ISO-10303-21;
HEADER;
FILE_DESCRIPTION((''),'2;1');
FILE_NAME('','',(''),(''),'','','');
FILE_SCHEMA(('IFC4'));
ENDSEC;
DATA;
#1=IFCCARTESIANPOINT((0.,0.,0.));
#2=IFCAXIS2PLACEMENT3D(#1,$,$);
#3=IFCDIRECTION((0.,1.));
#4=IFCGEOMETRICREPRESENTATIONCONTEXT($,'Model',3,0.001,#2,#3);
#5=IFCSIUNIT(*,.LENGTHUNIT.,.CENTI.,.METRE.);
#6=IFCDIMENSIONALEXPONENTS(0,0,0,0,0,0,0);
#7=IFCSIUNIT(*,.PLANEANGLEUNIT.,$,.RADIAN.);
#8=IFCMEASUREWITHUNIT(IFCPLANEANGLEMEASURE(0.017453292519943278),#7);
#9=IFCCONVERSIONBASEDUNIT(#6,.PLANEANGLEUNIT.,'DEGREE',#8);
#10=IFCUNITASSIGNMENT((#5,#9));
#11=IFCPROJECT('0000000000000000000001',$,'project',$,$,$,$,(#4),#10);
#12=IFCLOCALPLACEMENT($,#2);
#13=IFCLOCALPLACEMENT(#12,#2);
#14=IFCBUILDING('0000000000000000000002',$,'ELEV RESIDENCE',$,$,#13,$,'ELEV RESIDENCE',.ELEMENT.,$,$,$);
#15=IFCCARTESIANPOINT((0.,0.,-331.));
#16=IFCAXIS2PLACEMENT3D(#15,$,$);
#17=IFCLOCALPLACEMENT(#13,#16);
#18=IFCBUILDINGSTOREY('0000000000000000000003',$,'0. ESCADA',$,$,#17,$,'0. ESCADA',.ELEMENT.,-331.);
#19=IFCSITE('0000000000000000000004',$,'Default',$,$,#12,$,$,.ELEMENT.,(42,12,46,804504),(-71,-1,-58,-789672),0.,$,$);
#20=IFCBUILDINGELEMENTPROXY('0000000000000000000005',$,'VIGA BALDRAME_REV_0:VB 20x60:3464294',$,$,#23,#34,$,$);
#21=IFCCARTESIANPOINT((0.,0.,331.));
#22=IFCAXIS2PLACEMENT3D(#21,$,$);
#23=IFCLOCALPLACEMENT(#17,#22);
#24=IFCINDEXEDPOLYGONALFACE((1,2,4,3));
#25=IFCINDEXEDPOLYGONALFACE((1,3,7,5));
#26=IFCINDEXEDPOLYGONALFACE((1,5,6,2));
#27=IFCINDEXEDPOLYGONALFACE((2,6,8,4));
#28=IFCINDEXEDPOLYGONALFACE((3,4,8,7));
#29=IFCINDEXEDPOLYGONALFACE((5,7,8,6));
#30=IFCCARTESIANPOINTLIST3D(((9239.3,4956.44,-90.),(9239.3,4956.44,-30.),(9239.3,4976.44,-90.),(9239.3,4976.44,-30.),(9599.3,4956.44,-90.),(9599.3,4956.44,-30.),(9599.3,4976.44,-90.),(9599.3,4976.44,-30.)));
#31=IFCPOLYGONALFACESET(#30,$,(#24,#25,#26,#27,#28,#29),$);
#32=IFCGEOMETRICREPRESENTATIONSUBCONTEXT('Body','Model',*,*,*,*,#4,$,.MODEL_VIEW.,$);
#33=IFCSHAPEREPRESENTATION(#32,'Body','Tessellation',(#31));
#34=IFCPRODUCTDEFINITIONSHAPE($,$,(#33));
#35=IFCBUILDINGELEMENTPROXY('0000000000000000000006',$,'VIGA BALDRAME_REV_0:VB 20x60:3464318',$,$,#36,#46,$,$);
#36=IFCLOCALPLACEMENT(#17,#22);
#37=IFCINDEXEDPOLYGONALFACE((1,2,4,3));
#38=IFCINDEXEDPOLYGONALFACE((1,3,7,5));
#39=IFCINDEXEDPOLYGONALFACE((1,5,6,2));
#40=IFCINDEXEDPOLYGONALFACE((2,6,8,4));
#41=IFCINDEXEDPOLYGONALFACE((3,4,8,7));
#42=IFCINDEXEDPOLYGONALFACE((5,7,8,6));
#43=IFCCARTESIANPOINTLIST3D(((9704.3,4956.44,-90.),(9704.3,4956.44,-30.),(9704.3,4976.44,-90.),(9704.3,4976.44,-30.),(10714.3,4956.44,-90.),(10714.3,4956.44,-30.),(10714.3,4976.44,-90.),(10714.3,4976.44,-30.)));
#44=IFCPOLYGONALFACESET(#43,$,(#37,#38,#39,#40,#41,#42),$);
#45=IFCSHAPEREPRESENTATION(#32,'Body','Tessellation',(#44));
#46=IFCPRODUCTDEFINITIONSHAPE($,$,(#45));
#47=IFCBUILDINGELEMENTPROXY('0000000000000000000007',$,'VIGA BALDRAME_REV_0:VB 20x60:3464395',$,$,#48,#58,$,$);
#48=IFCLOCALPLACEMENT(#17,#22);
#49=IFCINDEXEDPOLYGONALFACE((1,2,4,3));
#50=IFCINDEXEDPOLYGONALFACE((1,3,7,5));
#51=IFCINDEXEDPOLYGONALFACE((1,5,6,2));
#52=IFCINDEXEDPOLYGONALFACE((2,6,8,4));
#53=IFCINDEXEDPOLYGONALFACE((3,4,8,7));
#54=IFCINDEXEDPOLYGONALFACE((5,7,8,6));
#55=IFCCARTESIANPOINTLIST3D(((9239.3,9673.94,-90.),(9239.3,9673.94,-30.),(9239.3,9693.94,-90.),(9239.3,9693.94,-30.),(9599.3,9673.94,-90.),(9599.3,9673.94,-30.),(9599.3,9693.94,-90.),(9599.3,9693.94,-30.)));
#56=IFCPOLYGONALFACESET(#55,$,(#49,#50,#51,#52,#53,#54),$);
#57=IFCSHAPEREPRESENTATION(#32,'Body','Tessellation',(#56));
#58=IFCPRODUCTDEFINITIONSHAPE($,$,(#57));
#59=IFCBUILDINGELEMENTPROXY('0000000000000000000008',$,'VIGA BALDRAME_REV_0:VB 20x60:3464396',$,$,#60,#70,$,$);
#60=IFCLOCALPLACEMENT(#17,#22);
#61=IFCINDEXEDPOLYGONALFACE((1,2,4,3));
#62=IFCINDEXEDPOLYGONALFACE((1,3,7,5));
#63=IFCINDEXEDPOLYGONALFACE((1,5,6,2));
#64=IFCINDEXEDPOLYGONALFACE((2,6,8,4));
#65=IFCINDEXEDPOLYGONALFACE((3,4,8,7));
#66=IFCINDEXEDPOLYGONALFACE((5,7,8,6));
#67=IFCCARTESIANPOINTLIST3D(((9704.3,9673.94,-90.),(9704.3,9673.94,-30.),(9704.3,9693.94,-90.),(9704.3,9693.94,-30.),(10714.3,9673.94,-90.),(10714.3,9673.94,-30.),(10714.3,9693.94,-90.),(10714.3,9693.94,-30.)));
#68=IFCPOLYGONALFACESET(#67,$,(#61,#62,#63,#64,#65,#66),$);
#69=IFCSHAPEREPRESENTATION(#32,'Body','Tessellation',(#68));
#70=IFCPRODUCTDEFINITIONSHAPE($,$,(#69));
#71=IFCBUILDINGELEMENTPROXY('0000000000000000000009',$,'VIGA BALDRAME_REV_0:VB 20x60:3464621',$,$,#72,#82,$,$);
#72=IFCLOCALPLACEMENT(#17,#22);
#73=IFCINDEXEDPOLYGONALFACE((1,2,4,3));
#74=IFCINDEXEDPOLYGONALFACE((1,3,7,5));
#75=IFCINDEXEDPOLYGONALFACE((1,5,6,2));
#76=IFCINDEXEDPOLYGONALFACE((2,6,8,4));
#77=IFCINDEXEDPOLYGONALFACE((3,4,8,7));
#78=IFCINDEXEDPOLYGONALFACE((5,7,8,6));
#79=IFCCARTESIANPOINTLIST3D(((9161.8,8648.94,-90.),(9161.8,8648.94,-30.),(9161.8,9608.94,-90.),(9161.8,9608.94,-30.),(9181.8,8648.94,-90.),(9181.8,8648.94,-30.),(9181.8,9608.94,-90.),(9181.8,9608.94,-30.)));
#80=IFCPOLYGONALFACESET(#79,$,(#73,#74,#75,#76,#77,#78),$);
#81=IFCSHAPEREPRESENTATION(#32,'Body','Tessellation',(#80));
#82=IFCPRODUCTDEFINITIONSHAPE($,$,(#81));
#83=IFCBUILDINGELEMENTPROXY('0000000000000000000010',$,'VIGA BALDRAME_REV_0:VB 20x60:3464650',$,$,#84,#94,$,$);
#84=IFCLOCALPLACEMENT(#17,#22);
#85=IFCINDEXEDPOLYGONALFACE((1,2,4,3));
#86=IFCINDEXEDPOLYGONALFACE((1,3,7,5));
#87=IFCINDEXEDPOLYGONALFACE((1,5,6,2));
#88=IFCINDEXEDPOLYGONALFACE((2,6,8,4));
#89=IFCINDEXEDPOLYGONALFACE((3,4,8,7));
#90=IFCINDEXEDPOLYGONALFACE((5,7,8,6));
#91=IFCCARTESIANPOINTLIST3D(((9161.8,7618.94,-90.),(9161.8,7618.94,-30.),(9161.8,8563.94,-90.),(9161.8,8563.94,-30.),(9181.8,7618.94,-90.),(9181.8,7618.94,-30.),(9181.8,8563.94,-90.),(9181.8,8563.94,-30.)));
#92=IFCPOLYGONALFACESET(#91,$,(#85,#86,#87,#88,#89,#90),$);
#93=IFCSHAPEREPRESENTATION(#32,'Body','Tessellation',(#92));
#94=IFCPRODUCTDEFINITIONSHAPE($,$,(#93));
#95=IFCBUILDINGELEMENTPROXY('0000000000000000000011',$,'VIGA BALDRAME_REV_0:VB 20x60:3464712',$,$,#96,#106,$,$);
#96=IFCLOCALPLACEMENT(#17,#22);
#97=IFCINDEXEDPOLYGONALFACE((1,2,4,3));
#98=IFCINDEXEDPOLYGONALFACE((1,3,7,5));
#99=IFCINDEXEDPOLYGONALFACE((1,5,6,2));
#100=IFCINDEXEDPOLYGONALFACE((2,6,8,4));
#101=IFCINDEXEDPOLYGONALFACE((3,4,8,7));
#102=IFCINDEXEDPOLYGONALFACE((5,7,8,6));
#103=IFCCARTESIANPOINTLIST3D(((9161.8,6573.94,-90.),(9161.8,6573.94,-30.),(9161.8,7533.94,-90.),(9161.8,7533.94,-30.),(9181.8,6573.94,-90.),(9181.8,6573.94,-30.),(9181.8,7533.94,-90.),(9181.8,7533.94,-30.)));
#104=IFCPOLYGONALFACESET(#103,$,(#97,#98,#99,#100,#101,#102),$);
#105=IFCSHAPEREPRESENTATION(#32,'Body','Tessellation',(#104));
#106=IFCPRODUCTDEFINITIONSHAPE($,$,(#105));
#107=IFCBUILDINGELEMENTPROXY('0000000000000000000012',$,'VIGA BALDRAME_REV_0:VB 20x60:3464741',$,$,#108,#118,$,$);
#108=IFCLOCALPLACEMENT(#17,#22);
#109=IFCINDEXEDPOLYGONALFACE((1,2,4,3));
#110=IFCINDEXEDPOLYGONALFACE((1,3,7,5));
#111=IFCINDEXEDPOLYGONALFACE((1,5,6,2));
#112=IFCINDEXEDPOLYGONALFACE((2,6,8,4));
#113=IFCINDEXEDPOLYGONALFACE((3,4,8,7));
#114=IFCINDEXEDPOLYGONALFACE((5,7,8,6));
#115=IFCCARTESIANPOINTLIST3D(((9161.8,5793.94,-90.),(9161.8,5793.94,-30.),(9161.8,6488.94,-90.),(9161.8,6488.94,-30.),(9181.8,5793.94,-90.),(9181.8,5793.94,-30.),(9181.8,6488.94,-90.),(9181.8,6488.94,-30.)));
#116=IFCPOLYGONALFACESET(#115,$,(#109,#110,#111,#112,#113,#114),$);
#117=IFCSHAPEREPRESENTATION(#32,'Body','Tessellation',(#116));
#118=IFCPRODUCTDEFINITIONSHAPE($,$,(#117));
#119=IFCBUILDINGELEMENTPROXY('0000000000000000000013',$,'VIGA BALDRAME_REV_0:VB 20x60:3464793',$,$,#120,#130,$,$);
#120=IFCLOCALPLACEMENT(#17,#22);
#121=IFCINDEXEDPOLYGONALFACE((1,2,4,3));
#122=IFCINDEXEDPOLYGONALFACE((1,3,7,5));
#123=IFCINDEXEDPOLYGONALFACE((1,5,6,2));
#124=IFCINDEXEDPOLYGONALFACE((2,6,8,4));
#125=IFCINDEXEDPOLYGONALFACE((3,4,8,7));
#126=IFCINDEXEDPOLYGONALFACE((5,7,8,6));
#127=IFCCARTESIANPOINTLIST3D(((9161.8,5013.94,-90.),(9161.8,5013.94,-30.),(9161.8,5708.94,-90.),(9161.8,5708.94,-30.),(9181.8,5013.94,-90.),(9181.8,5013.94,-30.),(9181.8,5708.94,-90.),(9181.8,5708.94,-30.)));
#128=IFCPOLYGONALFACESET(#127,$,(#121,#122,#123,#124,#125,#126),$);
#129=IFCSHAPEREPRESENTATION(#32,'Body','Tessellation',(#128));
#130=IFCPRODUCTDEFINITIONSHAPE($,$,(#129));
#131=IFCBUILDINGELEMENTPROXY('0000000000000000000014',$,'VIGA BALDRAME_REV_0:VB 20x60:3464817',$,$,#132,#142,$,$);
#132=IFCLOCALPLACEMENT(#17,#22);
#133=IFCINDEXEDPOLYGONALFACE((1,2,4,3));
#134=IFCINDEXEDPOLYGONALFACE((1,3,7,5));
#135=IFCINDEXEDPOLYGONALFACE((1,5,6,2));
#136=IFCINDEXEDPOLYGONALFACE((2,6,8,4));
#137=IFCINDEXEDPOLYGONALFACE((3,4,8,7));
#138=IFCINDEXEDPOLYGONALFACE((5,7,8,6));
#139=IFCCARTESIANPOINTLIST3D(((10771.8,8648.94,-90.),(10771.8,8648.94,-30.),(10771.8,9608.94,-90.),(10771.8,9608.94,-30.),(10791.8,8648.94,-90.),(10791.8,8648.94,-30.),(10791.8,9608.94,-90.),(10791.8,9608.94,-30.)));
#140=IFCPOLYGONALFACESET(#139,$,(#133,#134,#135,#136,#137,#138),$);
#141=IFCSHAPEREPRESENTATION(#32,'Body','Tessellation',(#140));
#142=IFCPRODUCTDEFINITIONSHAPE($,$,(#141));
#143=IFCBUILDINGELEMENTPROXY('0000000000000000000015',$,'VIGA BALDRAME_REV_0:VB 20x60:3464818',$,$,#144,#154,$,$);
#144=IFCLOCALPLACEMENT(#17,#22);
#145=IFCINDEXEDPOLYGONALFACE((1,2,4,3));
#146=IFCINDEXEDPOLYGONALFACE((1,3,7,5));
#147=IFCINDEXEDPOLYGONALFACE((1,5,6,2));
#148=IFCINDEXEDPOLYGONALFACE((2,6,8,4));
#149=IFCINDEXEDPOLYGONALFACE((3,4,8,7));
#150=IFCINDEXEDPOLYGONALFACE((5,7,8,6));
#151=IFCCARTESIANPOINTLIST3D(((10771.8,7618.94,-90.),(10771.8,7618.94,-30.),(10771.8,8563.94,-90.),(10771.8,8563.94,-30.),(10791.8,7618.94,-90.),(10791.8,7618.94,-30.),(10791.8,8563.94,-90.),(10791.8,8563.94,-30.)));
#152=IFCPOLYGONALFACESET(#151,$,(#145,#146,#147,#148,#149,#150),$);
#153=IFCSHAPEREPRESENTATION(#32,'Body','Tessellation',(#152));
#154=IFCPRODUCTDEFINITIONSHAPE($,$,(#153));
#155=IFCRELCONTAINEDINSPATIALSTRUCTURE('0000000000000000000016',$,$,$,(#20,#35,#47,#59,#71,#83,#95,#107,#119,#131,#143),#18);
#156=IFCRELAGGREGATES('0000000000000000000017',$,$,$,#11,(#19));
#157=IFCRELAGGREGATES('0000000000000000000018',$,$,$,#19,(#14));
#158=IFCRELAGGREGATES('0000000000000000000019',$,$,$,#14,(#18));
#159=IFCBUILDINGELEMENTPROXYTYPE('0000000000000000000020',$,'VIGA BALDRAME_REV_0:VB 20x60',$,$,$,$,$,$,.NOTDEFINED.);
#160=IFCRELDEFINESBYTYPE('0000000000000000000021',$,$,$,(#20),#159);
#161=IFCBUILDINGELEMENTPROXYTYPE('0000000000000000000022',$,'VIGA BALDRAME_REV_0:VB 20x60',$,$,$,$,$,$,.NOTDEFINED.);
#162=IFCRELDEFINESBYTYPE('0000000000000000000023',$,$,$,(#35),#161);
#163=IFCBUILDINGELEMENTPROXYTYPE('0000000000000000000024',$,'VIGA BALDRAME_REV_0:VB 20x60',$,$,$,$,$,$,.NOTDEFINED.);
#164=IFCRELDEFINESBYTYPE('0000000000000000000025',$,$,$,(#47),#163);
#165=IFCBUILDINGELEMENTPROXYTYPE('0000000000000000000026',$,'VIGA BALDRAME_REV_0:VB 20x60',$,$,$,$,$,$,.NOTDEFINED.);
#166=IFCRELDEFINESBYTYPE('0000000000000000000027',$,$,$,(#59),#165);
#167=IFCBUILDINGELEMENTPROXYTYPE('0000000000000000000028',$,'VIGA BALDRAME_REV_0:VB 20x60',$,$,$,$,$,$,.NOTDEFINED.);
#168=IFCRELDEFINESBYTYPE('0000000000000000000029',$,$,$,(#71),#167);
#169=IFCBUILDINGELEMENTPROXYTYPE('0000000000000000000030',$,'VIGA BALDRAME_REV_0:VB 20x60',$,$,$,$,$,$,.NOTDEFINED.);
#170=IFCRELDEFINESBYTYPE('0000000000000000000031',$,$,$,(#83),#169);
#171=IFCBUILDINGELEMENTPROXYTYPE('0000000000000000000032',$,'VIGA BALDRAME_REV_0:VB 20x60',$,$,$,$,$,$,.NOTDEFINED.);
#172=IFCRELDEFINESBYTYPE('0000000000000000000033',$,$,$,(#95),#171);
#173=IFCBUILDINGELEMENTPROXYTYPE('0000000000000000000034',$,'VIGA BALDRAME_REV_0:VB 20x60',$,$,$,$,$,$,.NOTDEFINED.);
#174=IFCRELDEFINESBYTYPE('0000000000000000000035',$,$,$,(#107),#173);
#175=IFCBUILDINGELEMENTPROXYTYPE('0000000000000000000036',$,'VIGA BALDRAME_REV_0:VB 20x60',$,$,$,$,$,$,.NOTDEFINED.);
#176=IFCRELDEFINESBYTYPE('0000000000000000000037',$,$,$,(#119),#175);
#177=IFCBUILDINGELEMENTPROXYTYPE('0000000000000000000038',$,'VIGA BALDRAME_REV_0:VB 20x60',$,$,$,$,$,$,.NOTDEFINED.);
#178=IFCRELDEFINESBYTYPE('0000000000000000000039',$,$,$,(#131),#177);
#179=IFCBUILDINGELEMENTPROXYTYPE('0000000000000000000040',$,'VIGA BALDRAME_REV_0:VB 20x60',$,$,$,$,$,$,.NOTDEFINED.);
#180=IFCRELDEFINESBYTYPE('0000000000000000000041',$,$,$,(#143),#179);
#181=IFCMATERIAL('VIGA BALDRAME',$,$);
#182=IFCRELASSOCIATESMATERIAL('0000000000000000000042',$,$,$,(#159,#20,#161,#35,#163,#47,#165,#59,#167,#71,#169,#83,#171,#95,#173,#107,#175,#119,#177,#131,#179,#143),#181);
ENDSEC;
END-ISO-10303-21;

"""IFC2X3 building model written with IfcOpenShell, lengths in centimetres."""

from ifc_helpers import new_model, entity, si_unit, converted_unit, direction, frame, frame_2d, origin, origin_2d_with_axis, place, context, subcontext, project, spatial, rectangle, extrude, source, transform, mapped, material, type_object, type_shapes, element, save


model = new_model("IFC2X3")

# Units and contexts
model_context = context("Model", 3, precision=0.001, world=origin(), true_north=direction((0.0, 1.0)))
body_context = subcontext(model_context, "Body", "Model", "MODEL_VIEW")
ifc_project = project(units=[si_unit("LENGTHUNIT", "METRE", prefix="CENTI"), converted_unit("PLANEANGLEUNIT", "DEGREE", entity("IfcPlaneAngleMeasure", 0.017453292519943278), si_unit("PLANEANGLEUNIT", "RADIAN"), dimensions=[0, 0, 0, 0, 0, 0, 0])], contexts=[model_context])

# Site, building, storey
site_placement = place(None, origin())
site = spatial("IfcSite", under=ifc_project, at=site_placement, Name="Default", CompositionType="ELEMENT", RefLatitude=(42, 12, 46, 804504), RefLongitude=(-71, -1, -58, -789672), RefElevation=0.0)
building_placement = place(site_placement, origin())
building = spatial("IfcBuilding", under=site, at=building_placement, Name="ELEV RESIDENCE", LongName="ELEV RESIDENCE", CompositionType="ELEMENT")
storey_placement = place(building_placement, frame((0.0, 0.0, -331.0)))
storey = spatial("IfcBuildingStorey", under=building, at=storey_placement, Name="0. ESCADA", LongName="0. ESCADA", CompositionType="ELEMENT", Elevation=-331.0)

# Building element proxies
ifc_material = material(Name="VIGA BALDRAME")
building_element_proxy_type_1 = type_object("IfcBuildingElementProxyType", Name="VIGA BALDRAME_REV_0:VB 20x60", PredefinedType="NOTDEFINED", material=ifc_material)
shared_shape_1 = source(origin(), body_context, "Body", "SweptSolid", [
    extrude(rectangle(XDim=360.0, YDim=20.0, at=frame_2d((0.0, 0.0), x_axis=(1.0, 0.0))), frame((9419.3, 4966.44, -90.0)), (0.0, 0.0, 1.0), 60.0),
])
type_shapes(building_element_proxy_type_1, [shared_shape_1])
proxy_1_placement = place(storey_placement, frame((0.0, 0.0, 331.0)))
element("IfcBuildingElementProxy", 1, at=proxy_1_placement, inside=storey, type_object=building_element_proxy_type_1, material=ifc_material, Name="VIGA BALDRAME_REV_0:VB 20x60:3464294", context=body_context, shape_type="MappedRepresentation", body=[
    mapped(shared_shape_1, transform((0.0, 0.0, 0.0), scale=1.0)),
])
building_element_proxy_type_2 = type_object("IfcBuildingElementProxyType", Name="VIGA BALDRAME_REV_0:VB 20x60", PredefinedType="NOTDEFINED", material=ifc_material)
shared_shape_2 = source(origin(), body_context, "Body", "SweptSolid", [
    extrude(rectangle(XDim=20.0, YDim=1010.0, at=frame_2d((0.0, 0.0), x_axis=(1.0, 0.0))), frame((10209.3, 4966.44, -90.0), z_axis=(0.0, 0.0, 1.0), x_axis=(0.0, 1.0, 0.0)), (0.0, 0.0, 1.0), 60.0),
])
type_shapes(building_element_proxy_type_2, [shared_shape_2])
proxy_2_placement = place(storey_placement, frame((0.0, 0.0, 331.0)))
element("IfcBuildingElementProxy", 2, at=proxy_2_placement, inside=storey, type_object=building_element_proxy_type_2, material=ifc_material, Name="VIGA BALDRAME_REV_0:VB 20x60:3464318", context=body_context, shape_type="MappedRepresentation", body=[
    mapped(shared_shape_2, transform((0.0, 0.0, 0.0), scale=1.0)),
])
building_element_proxy_type_3 = type_object("IfcBuildingElementProxyType", Name="VIGA BALDRAME_REV_0:VB 20x60", PredefinedType="NOTDEFINED", material=ifc_material)
shared_shape_3 = source(origin(), body_context, "Body", "SweptSolid", [
    extrude(rectangle(XDim=20.0, YDim=360.0, at=frame_2d((0.0, 0.0), x_axis=(1.0, 0.0))), frame((9419.3, 9683.94, -90.0), z_axis=(0.0, 0.0, 1.0), x_axis=(0.0, -1.0, 0.0)), (0.0, 0.0, 1.0), 60.0),
])
type_shapes(building_element_proxy_type_3, [shared_shape_3])
proxy_3_placement = place(storey_placement, frame((0.0, 0.0, 331.0)))
element("IfcBuildingElementProxy", 3, at=proxy_3_placement, inside=storey, type_object=building_element_proxy_type_3, material=ifc_material, Name="VIGA BALDRAME_REV_0:VB 20x60:3464395", context=body_context, shape_type="MappedRepresentation", body=[
    mapped(shared_shape_3, transform((0.0, 0.0, 0.0), scale=1.0)),
])
building_element_proxy_type_4 = type_object("IfcBuildingElementProxyType", Name="VIGA BALDRAME_REV_0:VB 20x60", PredefinedType="NOTDEFINED", material=ifc_material)
shared_shape_4 = source(origin(), body_context, "Body", "SweptSolid", [
    extrude(rectangle(XDim=1010.0, YDim=20.0, at=frame_2d((0.0, 0.0), x_axis=(1.0, 0.0))), frame((10209.3, 9683.94, -90.0), z_axis=(0.0, 0.0, 1.0), x_axis=(-1.0, 0.0, 0.0)), (0.0, 0.0, 1.0), 60.0),
])
type_shapes(building_element_proxy_type_4, [shared_shape_4])
proxy_4_placement = place(storey_placement, frame((0.0, 0.0, 331.0)))
element("IfcBuildingElementProxy", 4, at=proxy_4_placement, inside=storey, type_object=building_element_proxy_type_4, material=ifc_material, Name="VIGA BALDRAME_REV_0:VB 20x60:3464396", context=body_context, shape_type="MappedRepresentation", body=[
    mapped(shared_shape_4, transform((0.0, 0.0, 0.0), scale=1.0)),
])
building_element_proxy_type_5 = type_object("IfcBuildingElementProxyType", Name="VIGA BALDRAME_REV_0:VB 20x60", PredefinedType="NOTDEFINED", material=ifc_material)
shared_shape_5 = source(origin(), body_context, "Body", "SweptSolid", [
    extrude(rectangle(XDim=960.0, YDim=20.0, at=frame_2d((0.0, 0.0), x_axis=(1.0, 0.0))), frame((9171.8, 9128.94, -90.0), z_axis=(0.0, 0.0, 1.0), x_axis=(0.0, -1.0, 0.0)), (0.0, 0.0, 1.0), 60.0),
])
type_shapes(building_element_proxy_type_5, [shared_shape_5])
proxy_5_placement = place(storey_placement, frame((0.0, 0.0, 331.0)))
element("IfcBuildingElementProxy", 5, at=proxy_5_placement, inside=storey, type_object=building_element_proxy_type_5, material=ifc_material, Name="VIGA BALDRAME_REV_0:VB 20x60:3464621", context=body_context, shape_type="MappedRepresentation", body=[
    mapped(shared_shape_5, transform((0.0, 0.0, 0.0), scale=1.0)),
])
building_element_proxy_type_6 = type_object("IfcBuildingElementProxyType", Name="VIGA BALDRAME_REV_0:VB 20x60", PredefinedType="NOTDEFINED", material=ifc_material)
shared_shape_6 = source(origin(), body_context, "Body", "SweptSolid", [
    extrude(rectangle(XDim=20.0, YDim=945.0, at=frame_2d((0.0, 0.0), x_axis=(1.0, 0.0))), frame((9171.8, 8091.44, -90.0)), (0.0, 0.0, 1.0), 60.0),
])
type_shapes(building_element_proxy_type_6, [shared_shape_6])
proxy_6_placement = place(storey_placement, frame((0.0, 0.0, 331.0)))
element("IfcBuildingElementProxy", 6, at=proxy_6_placement, inside=storey, type_object=building_element_proxy_type_6, material=ifc_material, Name="VIGA BALDRAME_REV_0:VB 20x60:3464650", context=body_context, shape_type="MappedRepresentation", body=[
    mapped(shared_shape_6, transform((0.0, 0.0, 0.0), scale=1.0)),
])
building_element_proxy_type_7 = type_object("IfcBuildingElementProxyType", Name="VIGA BALDRAME_REV_0:VB 20x60", PredefinedType="NOTDEFINED", material=ifc_material)
shared_shape_7 = source(origin(), body_context, "Body", "SweptSolid", [
    extrude(rectangle(XDim=960.0, YDim=20.0, at=origin_2d_with_axis()), frame((9171.8, 7053.94, -90.0), z_axis=(0.0, 0.0, 1.0), x_axis=(0.0, -1.0, 0.0)), (0.0, 0.0, 1.0), 60.0),
])
type_shapes(building_element_proxy_type_7, [shared_shape_7])
proxy_7_placement = place(storey_placement, frame((0.0, 0.0, 331.0)))
element("IfcBuildingElementProxy", 7, at=proxy_7_placement, inside=storey, type_object=building_element_proxy_type_7, material=ifc_material, Name="VIGA BALDRAME_REV_0:VB 20x60:3464712", context=body_context, shape_type="MappedRepresentation", body=[
    mapped(shared_shape_7, transform((0.0, 0.0, 0.0), scale=1.0)),
])
building_element_proxy_type_8 = type_object("IfcBuildingElementProxyType", Name="VIGA BALDRAME_REV_0:VB 20x60", PredefinedType="NOTDEFINED", material=ifc_material)
shared_shape_8 = source(origin(), body_context, "Body", "SweptSolid", [
    extrude(rectangle(XDim=20.0, YDim=695.0, at=frame_2d((0.0, 0.0), x_axis=(1.0, 0.0))), frame((9171.8, 6141.44, -90.0)), (0.0, 0.0, 1.0), 60.0),
])
type_shapes(building_element_proxy_type_8, [shared_shape_8])
proxy_8_placement = place(storey_placement, frame((0.0, 0.0, 331.0)))
element("IfcBuildingElementProxy", 8, at=proxy_8_placement, inside=storey, type_object=building_element_proxy_type_8, material=ifc_material, Name="VIGA BALDRAME_REV_0:VB 20x60:3464741", context=body_context, shape_type="MappedRepresentation", body=[
    mapped(shared_shape_8, transform((0.0, 0.0, 0.0), scale=1.0)),
])
building_element_proxy_type_9 = type_object("IfcBuildingElementProxyType", Name="VIGA BALDRAME_REV_0:VB 20x60", PredefinedType="NOTDEFINED", material=ifc_material)
shared_shape_9 = source(origin(), body_context, "Body", "SweptSolid", [
    extrude(rectangle(XDim=695.0, YDim=20.0, at=frame_2d((0.0, 0.0), x_axis=(1.0, 0.0))), frame((9171.8, 5361.44, -90.0), z_axis=(0.0, 0.0, 1.0), x_axis=(0.0, -1.0, 0.0)), (0.0, 0.0, 1.0), 60.0),
])
type_shapes(building_element_proxy_type_9, [shared_shape_9])
proxy_9_placement = place(storey_placement, frame((0.0, 0.0, 331.0)))
element("IfcBuildingElementProxy", 9, at=proxy_9_placement, inside=storey, type_object=building_element_proxy_type_9, material=ifc_material, Name="VIGA BALDRAME_REV_0:VB 20x60:3464793", context=body_context, shape_type="MappedRepresentation", body=[
    mapped(shared_shape_9, transform((0.0, 0.0, 0.0), scale=1.0)),
])
building_element_proxy_type_10 = type_object("IfcBuildingElementProxyType", Name="VIGA BALDRAME_REV_0:VB 20x60", PredefinedType="NOTDEFINED", material=ifc_material)
shared_shape_10 = source(origin(), body_context, "Body", "SweptSolid", [
    extrude(rectangle(XDim=20.0, YDim=960.0, at=origin_2d_with_axis()), frame((10781.8, 9128.94, -90.0), z_axis=(0.0, 0.0, 1.0), x_axis=(-1.0, 0.0, 0.0)), (0.0, 0.0, 1.0), 60.0),
])
type_shapes(building_element_proxy_type_10, [shared_shape_10])
proxy_10_placement = place(storey_placement, frame((0.0, 0.0, 331.0)))
element("IfcBuildingElementProxy", 10, at=proxy_10_placement, inside=storey, type_object=building_element_proxy_type_10, material=ifc_material, Name="VIGA BALDRAME_REV_0:VB 20x60:3464817", context=body_context, shape_type="MappedRepresentation", body=[
    mapped(shared_shape_10, transform((0.0, 0.0, 0.0), scale=1.0)),
])
building_element_proxy_type_11 = type_object("IfcBuildingElementProxyType", Name="VIGA BALDRAME_REV_0:VB 20x60", PredefinedType="NOTDEFINED", material=ifc_material)
shared_shape_11 = source(origin(), body_context, "Body", "SweptSolid", [
    extrude(rectangle(XDim=945.0, YDim=20.0, at=frame_2d((0.0, 0.0), x_axis=(1.0, 0.0))), frame((10781.8, 8091.44, -90.0), z_axis=(0.0, 0.0, 1.0), x_axis=(0.0, 1.0, 0.0)), (0.0, 0.0, 1.0), 60.0),
])
type_shapes(building_element_proxy_type_11, [shared_shape_11])
proxy_11_placement = place(storey_placement, frame((0.0, 0.0, 331.0)))
element("IfcBuildingElementProxy", 11, at=proxy_11_placement, inside=storey, type_object=building_element_proxy_type_11, material=ifc_material, Name="VIGA BALDRAME_REV_0:VB 20x60:3464818", context=body_context, shape_type="MappedRepresentation", body=[
    mapped(shared_shape_11, transform((0.0, 0.0, 0.0), scale=1.0)),
])

save(model, "model.ifc")
